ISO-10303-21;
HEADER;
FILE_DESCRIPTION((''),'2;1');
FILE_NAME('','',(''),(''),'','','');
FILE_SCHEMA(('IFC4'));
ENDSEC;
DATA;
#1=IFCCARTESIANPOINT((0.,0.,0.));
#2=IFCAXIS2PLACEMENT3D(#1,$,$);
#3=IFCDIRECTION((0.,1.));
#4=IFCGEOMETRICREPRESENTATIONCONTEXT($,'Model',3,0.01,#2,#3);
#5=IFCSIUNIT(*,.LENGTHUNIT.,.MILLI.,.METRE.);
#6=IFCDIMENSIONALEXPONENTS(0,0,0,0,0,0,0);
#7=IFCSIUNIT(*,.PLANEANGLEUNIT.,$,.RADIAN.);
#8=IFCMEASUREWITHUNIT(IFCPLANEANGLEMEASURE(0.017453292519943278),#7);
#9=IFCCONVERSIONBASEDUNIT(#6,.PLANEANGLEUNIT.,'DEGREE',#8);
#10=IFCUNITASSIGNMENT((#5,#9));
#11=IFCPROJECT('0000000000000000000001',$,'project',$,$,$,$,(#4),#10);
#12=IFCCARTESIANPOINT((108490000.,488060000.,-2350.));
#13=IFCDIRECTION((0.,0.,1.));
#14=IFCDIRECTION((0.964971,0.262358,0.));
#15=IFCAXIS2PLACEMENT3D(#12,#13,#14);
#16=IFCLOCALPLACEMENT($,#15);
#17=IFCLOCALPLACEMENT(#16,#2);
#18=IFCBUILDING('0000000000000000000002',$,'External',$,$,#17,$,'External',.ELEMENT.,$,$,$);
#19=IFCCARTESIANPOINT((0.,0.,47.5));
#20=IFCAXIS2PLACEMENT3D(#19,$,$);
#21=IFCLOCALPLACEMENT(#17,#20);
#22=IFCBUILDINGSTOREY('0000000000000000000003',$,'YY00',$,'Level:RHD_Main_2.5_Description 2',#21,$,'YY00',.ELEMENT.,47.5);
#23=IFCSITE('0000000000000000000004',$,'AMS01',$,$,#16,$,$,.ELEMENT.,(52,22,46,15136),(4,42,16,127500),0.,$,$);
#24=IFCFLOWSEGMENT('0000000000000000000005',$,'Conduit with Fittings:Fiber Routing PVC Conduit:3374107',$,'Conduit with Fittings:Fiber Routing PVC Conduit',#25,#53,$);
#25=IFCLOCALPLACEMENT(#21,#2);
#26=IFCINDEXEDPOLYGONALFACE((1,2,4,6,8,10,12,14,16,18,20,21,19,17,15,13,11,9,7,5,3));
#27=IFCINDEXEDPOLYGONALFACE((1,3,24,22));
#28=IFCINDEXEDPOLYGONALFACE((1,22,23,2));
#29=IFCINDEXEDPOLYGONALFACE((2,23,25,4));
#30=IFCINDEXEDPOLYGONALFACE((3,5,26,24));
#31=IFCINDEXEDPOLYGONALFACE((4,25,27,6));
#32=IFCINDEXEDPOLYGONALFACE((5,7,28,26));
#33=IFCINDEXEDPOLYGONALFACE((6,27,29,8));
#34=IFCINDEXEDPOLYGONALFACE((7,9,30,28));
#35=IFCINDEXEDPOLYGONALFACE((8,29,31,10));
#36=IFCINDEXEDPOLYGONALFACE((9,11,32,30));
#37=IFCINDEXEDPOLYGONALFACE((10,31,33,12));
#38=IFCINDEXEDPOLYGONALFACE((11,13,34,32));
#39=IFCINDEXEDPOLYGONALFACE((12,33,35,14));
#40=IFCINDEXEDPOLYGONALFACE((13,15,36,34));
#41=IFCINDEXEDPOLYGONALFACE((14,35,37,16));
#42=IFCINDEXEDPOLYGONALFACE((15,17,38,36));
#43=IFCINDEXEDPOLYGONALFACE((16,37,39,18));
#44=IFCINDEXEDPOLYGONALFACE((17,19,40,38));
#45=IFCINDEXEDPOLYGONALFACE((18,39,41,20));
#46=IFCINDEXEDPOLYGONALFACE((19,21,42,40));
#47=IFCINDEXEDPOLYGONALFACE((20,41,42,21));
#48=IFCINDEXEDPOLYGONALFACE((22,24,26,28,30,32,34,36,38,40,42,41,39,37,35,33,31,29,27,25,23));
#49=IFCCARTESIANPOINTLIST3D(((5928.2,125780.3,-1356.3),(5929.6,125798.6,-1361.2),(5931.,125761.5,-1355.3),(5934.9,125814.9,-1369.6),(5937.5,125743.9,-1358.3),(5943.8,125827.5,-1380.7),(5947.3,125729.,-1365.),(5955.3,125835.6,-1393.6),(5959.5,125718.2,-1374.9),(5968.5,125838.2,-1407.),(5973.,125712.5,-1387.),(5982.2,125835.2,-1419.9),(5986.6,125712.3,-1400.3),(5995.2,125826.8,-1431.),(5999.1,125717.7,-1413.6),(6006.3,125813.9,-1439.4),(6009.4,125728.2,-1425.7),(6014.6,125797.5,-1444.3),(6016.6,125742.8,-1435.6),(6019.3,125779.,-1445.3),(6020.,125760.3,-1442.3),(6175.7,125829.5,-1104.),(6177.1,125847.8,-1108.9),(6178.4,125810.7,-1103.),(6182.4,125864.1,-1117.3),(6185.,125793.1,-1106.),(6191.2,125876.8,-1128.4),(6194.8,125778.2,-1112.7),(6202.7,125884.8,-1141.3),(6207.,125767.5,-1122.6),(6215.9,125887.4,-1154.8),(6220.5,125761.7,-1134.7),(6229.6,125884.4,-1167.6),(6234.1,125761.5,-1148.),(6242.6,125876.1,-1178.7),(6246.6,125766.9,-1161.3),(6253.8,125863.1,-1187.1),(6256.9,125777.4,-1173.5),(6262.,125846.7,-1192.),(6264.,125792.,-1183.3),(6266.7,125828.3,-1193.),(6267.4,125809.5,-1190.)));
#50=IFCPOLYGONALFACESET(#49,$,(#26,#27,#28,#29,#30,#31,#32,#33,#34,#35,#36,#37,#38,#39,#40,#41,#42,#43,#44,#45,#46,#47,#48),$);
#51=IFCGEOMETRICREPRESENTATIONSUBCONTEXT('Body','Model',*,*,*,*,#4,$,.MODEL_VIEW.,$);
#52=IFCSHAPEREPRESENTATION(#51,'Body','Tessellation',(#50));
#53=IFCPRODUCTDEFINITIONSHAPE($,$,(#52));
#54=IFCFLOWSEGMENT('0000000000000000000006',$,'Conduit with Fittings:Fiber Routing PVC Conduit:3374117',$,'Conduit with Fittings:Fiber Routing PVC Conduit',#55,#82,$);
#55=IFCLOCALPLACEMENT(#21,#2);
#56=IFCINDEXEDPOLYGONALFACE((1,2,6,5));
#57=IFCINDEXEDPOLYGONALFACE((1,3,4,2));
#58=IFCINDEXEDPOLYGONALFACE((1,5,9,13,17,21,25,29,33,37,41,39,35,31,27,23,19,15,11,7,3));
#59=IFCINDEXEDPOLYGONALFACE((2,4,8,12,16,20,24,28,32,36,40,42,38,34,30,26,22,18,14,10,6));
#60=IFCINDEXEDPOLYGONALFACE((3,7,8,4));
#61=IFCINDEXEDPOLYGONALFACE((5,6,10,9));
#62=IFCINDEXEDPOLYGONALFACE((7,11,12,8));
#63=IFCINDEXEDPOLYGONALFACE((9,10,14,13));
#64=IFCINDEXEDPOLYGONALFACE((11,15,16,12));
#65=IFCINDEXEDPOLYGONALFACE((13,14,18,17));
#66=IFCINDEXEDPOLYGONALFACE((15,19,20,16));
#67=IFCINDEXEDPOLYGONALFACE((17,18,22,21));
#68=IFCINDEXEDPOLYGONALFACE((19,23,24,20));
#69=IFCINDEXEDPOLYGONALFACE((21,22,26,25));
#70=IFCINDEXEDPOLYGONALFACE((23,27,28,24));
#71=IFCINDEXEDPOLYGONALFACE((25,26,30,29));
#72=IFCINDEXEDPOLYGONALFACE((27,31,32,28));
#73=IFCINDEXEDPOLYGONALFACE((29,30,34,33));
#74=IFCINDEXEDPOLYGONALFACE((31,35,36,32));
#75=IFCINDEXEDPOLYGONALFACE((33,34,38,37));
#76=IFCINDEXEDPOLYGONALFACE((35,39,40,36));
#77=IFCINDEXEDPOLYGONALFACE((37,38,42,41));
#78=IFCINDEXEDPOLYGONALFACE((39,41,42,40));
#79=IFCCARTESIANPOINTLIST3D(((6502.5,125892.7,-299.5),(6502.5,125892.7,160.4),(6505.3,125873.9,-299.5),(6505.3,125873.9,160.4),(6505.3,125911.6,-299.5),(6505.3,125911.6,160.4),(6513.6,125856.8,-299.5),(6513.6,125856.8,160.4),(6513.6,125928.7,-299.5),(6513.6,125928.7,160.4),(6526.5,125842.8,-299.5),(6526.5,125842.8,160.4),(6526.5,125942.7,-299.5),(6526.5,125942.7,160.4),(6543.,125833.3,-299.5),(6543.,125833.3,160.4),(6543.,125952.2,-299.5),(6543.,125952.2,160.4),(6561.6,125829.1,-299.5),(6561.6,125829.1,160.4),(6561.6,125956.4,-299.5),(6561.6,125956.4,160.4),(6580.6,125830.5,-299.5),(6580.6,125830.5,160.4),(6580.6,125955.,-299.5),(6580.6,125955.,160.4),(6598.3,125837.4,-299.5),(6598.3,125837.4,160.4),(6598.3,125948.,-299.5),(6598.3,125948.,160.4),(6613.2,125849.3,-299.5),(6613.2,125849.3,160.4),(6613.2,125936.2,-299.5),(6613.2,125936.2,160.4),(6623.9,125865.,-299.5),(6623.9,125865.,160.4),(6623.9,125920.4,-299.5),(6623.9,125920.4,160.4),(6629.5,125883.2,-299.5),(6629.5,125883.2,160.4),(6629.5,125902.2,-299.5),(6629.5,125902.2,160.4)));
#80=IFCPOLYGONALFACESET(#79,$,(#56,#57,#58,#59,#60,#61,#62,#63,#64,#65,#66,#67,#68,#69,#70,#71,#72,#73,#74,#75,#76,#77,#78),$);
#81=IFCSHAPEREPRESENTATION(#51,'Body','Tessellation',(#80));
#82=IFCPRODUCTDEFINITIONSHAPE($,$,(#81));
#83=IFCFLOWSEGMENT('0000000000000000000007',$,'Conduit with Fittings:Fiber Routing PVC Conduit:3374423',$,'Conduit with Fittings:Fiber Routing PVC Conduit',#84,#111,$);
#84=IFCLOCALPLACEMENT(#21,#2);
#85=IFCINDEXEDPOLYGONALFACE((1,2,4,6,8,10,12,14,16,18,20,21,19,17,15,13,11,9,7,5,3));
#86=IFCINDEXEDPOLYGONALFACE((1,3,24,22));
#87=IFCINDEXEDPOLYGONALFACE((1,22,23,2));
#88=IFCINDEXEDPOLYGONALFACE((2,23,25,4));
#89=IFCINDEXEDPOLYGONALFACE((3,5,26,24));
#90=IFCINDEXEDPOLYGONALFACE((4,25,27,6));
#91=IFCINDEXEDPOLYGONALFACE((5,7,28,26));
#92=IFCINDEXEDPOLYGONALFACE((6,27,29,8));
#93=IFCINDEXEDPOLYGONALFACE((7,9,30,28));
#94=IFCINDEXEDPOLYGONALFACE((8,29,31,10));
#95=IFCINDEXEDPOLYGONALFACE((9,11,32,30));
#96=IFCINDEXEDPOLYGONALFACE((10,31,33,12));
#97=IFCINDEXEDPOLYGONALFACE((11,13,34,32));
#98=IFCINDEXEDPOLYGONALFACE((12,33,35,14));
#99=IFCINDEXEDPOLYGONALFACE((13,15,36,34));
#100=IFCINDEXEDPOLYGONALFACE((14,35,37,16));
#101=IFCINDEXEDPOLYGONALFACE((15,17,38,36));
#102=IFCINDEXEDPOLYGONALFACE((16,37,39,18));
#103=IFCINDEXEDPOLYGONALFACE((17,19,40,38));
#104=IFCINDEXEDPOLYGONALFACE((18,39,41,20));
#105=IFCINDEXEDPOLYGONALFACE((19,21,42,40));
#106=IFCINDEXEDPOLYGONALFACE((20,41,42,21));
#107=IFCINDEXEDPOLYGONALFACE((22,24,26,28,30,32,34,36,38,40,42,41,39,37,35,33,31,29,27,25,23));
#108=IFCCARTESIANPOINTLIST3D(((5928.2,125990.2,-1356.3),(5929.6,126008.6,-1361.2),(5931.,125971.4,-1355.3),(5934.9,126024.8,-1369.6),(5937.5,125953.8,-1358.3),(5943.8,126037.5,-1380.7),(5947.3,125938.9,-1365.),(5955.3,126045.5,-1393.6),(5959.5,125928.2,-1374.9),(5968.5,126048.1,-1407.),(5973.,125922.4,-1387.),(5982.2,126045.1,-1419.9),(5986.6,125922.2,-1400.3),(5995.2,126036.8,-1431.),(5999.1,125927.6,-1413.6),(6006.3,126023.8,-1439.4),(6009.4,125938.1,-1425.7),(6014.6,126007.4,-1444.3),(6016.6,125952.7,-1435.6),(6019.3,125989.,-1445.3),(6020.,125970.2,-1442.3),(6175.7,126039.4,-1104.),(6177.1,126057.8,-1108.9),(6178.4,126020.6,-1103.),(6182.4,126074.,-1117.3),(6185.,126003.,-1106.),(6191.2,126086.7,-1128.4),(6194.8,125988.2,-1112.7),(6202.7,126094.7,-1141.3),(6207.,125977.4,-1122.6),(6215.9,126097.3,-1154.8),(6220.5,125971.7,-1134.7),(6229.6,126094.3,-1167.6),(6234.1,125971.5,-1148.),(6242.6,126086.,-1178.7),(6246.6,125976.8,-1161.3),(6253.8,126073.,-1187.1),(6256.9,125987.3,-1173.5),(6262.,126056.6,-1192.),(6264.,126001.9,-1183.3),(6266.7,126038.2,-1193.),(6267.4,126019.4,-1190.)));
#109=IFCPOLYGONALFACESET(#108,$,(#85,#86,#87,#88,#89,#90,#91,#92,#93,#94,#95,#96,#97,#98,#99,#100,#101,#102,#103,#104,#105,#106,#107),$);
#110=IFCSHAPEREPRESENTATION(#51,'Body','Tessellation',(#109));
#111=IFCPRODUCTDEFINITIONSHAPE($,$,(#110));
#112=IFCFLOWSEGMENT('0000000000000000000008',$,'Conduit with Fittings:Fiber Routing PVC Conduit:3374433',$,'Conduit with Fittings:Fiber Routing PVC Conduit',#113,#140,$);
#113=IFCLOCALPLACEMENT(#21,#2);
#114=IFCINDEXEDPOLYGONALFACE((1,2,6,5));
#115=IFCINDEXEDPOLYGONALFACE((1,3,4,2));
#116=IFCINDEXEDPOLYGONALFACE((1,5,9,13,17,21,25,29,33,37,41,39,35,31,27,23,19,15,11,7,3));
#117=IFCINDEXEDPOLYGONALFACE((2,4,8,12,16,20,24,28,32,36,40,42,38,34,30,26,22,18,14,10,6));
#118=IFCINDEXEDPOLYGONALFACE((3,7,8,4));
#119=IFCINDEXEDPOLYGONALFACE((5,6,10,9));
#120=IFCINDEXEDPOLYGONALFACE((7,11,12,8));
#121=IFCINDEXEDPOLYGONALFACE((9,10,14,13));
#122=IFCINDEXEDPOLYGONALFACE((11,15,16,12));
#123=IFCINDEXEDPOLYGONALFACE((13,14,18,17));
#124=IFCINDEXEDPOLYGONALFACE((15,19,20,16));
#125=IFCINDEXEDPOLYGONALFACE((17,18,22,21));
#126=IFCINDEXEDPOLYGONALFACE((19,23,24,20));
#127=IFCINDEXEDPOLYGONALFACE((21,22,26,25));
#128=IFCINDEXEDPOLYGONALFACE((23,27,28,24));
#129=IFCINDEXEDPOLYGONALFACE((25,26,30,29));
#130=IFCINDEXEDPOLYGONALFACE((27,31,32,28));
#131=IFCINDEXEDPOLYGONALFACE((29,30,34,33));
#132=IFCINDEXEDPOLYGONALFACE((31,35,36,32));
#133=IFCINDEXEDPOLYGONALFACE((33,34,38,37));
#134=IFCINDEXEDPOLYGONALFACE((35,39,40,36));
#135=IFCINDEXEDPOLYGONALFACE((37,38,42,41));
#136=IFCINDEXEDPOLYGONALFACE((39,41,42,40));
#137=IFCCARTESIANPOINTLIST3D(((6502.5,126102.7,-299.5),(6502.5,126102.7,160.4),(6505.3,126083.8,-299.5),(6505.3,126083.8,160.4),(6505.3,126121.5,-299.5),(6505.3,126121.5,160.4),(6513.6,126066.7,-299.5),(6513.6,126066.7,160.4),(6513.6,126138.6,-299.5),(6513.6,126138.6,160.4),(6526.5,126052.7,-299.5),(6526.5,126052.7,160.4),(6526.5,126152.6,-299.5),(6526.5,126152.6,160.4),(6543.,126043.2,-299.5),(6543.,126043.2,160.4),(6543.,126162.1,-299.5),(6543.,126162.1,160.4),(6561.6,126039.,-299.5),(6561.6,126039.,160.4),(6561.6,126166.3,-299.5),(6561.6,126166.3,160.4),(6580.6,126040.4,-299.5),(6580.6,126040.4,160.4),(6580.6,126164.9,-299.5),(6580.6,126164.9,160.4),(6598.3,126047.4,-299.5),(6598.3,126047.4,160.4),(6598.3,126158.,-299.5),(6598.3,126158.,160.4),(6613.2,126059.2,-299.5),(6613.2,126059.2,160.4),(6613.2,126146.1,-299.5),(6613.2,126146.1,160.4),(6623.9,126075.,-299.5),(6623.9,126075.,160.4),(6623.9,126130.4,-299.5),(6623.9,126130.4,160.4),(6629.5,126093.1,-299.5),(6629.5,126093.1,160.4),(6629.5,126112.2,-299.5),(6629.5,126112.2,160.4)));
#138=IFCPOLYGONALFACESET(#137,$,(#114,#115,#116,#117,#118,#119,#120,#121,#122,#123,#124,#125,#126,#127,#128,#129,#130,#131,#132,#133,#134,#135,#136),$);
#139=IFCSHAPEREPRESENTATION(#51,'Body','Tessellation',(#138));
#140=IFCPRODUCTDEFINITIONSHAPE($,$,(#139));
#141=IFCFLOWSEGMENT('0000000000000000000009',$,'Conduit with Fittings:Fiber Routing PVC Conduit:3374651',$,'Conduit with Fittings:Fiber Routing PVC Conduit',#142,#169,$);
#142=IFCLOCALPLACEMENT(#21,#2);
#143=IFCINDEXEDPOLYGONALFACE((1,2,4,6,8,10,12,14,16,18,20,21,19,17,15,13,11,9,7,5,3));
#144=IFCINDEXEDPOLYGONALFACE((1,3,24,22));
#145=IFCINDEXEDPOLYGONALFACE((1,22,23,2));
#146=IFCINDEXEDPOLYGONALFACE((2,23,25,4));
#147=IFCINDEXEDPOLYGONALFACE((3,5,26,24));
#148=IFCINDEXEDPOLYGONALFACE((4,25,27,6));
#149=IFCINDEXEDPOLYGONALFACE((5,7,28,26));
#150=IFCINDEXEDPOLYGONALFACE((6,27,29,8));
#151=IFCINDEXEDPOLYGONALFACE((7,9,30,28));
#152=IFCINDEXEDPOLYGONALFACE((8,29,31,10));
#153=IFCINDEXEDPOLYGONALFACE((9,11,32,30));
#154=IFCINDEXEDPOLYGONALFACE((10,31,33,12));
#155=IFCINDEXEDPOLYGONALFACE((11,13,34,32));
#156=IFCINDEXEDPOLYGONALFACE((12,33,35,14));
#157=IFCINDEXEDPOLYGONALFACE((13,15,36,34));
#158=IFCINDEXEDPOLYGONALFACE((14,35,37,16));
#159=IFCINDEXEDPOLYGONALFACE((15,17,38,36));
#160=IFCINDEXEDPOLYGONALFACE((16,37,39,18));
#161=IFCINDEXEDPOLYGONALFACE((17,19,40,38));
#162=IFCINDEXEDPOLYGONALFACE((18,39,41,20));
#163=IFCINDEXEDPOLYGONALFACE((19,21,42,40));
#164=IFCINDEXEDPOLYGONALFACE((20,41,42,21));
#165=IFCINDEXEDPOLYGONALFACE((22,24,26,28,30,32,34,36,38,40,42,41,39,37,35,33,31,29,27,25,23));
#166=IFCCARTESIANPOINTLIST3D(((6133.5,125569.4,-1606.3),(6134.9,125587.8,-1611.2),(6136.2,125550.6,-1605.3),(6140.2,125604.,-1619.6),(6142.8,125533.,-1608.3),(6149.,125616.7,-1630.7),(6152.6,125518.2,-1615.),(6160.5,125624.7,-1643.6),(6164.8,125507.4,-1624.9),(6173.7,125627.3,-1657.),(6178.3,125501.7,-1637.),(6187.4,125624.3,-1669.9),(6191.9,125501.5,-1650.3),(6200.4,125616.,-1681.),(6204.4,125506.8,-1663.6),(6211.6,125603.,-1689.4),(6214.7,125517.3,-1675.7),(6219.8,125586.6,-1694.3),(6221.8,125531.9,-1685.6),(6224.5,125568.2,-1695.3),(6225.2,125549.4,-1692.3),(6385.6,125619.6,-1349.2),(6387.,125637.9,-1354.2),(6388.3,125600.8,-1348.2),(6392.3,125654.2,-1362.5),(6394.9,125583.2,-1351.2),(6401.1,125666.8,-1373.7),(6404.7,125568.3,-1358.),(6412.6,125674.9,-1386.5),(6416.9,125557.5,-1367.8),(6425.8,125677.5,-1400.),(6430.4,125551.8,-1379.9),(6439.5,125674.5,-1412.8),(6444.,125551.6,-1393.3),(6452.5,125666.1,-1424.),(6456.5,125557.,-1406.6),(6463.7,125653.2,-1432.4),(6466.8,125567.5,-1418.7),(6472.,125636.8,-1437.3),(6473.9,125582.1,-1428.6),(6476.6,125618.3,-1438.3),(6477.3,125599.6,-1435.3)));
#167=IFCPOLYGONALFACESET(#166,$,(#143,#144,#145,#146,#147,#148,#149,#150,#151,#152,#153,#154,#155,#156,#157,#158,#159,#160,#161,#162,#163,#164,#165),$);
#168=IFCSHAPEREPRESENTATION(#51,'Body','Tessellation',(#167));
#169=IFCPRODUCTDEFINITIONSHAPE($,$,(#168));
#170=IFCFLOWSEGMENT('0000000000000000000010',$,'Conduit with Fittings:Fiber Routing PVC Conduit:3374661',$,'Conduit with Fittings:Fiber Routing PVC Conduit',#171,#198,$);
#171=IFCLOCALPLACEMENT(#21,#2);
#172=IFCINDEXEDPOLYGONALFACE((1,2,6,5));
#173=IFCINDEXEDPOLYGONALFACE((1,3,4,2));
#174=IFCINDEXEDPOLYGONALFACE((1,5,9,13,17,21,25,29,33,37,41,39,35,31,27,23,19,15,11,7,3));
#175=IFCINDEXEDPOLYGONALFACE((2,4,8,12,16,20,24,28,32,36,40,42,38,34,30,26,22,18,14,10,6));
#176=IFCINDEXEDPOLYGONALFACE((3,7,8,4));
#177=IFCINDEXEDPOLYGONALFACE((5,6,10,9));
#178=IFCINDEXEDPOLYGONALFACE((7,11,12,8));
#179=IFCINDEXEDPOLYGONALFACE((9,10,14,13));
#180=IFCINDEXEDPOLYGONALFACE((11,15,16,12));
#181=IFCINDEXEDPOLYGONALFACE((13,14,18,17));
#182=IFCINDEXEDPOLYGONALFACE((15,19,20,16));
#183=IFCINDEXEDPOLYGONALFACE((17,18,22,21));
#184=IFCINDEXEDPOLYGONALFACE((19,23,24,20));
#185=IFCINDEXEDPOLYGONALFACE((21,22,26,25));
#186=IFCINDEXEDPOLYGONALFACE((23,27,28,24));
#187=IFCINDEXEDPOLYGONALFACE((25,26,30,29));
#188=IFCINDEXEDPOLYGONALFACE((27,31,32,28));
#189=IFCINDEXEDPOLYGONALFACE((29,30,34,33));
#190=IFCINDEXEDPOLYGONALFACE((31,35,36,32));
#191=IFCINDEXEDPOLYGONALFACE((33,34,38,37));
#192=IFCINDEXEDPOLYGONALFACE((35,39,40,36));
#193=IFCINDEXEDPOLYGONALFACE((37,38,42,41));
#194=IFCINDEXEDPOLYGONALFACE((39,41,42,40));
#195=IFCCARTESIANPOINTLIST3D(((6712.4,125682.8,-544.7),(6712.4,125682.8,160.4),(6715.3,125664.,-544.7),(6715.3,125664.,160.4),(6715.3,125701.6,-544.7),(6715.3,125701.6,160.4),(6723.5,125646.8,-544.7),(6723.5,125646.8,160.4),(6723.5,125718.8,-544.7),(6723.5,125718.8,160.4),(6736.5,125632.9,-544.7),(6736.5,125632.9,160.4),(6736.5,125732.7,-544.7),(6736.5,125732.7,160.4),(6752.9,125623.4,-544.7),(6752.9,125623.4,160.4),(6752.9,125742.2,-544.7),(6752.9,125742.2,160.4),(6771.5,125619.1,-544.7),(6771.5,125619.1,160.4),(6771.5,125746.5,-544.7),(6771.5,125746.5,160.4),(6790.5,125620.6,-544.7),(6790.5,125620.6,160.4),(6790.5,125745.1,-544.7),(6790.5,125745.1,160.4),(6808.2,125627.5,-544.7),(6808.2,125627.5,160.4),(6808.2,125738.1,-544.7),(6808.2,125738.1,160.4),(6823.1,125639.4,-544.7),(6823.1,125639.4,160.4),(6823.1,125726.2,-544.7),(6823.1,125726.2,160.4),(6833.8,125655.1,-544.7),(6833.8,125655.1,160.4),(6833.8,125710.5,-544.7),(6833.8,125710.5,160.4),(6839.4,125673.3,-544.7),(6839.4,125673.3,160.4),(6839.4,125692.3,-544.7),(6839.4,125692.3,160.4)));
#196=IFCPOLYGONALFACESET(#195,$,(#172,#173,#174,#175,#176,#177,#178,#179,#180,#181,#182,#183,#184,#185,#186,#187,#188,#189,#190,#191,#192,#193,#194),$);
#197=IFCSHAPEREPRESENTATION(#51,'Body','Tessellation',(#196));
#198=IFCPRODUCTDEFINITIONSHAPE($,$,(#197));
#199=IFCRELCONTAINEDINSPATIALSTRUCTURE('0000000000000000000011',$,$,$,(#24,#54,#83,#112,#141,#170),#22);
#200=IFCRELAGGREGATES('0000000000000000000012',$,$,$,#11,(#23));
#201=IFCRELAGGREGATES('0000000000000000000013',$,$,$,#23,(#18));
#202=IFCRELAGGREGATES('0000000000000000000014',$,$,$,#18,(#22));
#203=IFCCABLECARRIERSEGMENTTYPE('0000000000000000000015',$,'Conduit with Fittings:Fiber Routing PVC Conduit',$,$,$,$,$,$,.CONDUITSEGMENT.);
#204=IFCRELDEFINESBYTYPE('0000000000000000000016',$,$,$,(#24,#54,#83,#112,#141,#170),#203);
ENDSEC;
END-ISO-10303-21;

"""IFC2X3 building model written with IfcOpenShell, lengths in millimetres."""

from ifc_helpers import new_model, entity, si_unit, converted_unit, direction, frame, frame_2d, origin, origin_2d_with_axis, place, context, subcontext, project, spatial, circle, extrude, type_object, element, save


model = new_model("IFC2X3")

# Units and contexts
model_context = context("Model", 3, precision=0.01, world=origin(), true_north=direction((0.0, 1.0)))
body_context = subcontext(model_context, "Body", "Model", "MODEL_VIEW")
ifc_project = project(units=[si_unit("LENGTHUNIT", "METRE", prefix="MILLI"), converted_unit("PLANEANGLEUNIT", "DEGREE", entity("IfcPlaneAngleMeasure", 0.017453292519943278), si_unit("PLANEANGLEUNIT", "RADIAN"), dimensions=[0, 0, 0, 0, 0, 0, 0])], contexts=[model_context])

# Site, building, storey
site_placement = place(None, frame((108490000.0, 488060000.0, -2350.0), z_axis=(0.0, 0.0, 1.0), x_axis=(0.964971, 0.262358, 0.0)))
site = spatial("IfcSite", under=ifc_project, at=site_placement, Name="AMS01", CompositionType="ELEMENT", RefLatitude=(52, 22, 46, 15136), RefLongitude=(4, 42, 16, 127500), RefElevation=0.0)
building_placement = place(site_placement, origin())
building = spatial("IfcBuilding", under=site, at=building_placement, Name="External", LongName="External", CompositionType="ELEMENT")
storey_placement = place(building_placement, frame((0.0, 0.0, 47.5)))
storey = spatial("IfcBuildingStorey", under=building, at=storey_placement, Name="YY00", ObjectType="Level:RHD_Main_2.5_Description 2", LongName="YY00", CompositionType="ELEMENT", Elevation=47.5)

# Flow segments
cable_carrier_segment_type = type_object("IfcCableCarrierSegmentType", Name="Conduit with Fittings:Fiber Routing PVC Conduit", PredefinedType="CONDUITSEGMENT")
flow_segment_1_placement = place(storey_placement, origin())
element("IfcFlowSegment", 1, at=flow_segment_1_placement, inside=storey, type_object=cable_carrier_segment_type, Name="Conduit with Fittings:Fiber Routing PVC Conduit:3374107", ObjectType="Conduit with Fittings:Fiber Routing PVC Conduit", context=body_context, shape_type="SweptSolid", body=[
    extrude(circle(Radius=63.9, at=frame_2d((0.0, 0.0), x_axis=(1.0, 0.0))), frame((5974.2, 125774.9, -1400.3), z_axis=(0.69352, 0.13795, 0.707107), x_axis=(0.19509, -0.980785, 0.0)), (0.0, 0.0, 1.0), 356.8),
])
flow_segment_2_placement = place(storey_placement, origin())
element("IfcFlowSegment", 2, at=flow_segment_2_placement, inside=storey, type_object=cable_carrier_segment_type, Name="Conduit with Fittings:Fiber Routing PVC Conduit:3374117", ObjectType="Conduit with Fittings:Fiber Routing PVC Conduit", context=body_context, shape_type="SweptSolid", body=[
    extrude(circle(Radius=63.9, at=origin_2d_with_axis()), frame((6566.4, 125892.7, -299.5), z_axis=(0.0, 0.0, 1.0), x_axis=(-1.0, 0.0, 0.0)), (0.0, 0.0, 1.0), 459.8),
])
flow_segment_3_placement = place(storey_placement, origin())
element("IfcFlowSegment", 3, at=flow_segment_3_placement, inside=storey, type_object=cable_carrier_segment_type, Name="Conduit with Fittings:Fiber Routing PVC Conduit:3374423", ObjectType="Conduit with Fittings:Fiber Routing PVC Conduit", context=body_context, shape_type="SweptSolid", body=[
    extrude(circle(Radius=63.9, at=frame_2d((0.0, 0.0), x_axis=(1.0, 0.0))), frame((5974.2, 125984.9, -1400.3), z_axis=(0.69352, 0.13795, 0.707107), x_axis=(0.19509, -0.980785, 0.0)), (0.0, 0.0, 1.0), 356.8),
])
flow_segment_4_placement = place(storey_placement, origin())
element("IfcFlowSegment", 4, at=flow_segment_4_placement, inside=storey, type_object=cable_carrier_segment_type, Name="Conduit with Fittings:Fiber Routing PVC Conduit:3374433", ObjectType="Conduit with Fittings:Fiber Routing PVC Conduit", context=body_context, shape_type="SweptSolid", body=[
    extrude(circle(Radius=63.9, at=origin_2d_with_axis()), frame((6566.4, 126102.7, -299.5), z_axis=(0.0, 0.0, 1.0), x_axis=(-1.0, 0.0, 0.0)), (0.0, 0.0, 1.0), 459.8),
])
flow_segment_5_placement = place(storey_placement, origin())
element("IfcFlowSegment", 5, at=flow_segment_5_placement, inside=storey, type_object=cable_carrier_segment_type, Name="Conduit with Fittings:Fiber Routing PVC Conduit:3374651", ObjectType="Conduit with Fittings:Fiber Routing PVC Conduit", context=body_context, shape_type="SweptSolid", body=[
    extrude(circle(Radius=63.9, at=frame_2d((0.0, 0.0), x_axis=(1.0, 0.0))), frame((6179.4, 125564.1, -1650.3), z_axis=(0.69352, 0.13795, 0.707107), x_axis=(0.19509, -0.980785, 0.0)), (0.0, 0.0, 1.0), 363.5),
])
flow_segment_6_placement = place(storey_placement, origin())
element("IfcFlowSegment", 6, at=flow_segment_6_placement, inside=storey, type_object=cable_carrier_segment_type, Name="Conduit with Fittings:Fiber Routing PVC Conduit:3374661", ObjectType="Conduit with Fittings:Fiber Routing PVC Conduit", context=body_context, shape_type="SweptSolid", body=[
    extrude(circle(Radius=63.9, at=origin_2d_with_axis()), frame((6776.3, 125682.8, -544.7), z_axis=(0.0, 0.0, 1.0), x_axis=(-1.0, 0.0, 0.0)), (0.0, 0.0, 1.0), 705.1),
])

save(model, "model.ifc")
